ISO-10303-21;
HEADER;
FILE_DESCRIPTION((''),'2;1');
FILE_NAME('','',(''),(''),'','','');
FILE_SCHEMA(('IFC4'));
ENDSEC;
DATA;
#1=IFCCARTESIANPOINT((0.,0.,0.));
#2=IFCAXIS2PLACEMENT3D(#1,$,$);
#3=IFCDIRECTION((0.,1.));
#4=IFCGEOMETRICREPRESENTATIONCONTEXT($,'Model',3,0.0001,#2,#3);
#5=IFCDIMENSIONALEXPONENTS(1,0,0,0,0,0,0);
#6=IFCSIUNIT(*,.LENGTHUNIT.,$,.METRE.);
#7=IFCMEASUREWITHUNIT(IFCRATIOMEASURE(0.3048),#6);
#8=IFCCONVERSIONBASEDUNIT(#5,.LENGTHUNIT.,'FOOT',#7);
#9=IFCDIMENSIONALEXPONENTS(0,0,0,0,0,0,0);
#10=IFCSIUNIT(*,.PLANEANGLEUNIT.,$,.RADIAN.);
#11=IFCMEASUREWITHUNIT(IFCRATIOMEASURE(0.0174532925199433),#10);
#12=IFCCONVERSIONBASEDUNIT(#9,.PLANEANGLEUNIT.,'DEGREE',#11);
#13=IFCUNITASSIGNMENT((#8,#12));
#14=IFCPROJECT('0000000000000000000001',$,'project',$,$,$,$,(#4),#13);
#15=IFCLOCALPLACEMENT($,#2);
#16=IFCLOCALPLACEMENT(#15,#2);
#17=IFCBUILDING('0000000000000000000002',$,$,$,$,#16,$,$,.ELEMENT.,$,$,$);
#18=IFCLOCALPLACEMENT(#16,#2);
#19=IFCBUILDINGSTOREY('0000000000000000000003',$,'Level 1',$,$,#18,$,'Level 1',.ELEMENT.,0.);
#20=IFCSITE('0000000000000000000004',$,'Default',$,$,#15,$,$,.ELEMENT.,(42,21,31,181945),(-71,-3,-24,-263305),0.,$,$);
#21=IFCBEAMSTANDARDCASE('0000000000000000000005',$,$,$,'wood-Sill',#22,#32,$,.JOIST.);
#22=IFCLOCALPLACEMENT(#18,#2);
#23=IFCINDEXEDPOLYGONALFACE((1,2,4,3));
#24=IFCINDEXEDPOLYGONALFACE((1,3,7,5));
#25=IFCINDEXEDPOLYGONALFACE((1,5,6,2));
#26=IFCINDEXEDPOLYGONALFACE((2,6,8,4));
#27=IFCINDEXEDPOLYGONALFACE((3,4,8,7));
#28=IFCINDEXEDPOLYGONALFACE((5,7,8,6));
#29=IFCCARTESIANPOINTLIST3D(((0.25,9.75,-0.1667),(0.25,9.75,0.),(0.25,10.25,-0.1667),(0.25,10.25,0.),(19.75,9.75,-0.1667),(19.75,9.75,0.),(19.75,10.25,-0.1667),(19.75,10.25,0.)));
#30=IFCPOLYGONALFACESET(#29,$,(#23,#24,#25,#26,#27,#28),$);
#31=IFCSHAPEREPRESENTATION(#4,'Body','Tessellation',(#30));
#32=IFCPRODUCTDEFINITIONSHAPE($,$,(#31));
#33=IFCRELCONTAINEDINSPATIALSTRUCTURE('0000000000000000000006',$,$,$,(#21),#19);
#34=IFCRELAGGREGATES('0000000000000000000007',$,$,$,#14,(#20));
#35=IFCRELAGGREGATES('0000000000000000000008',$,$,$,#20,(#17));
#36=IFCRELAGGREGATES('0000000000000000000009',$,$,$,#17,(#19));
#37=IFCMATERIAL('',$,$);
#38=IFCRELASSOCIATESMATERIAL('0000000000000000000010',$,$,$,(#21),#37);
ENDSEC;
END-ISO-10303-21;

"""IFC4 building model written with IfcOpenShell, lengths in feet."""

from ifc_helpers import new_model, entity, si_unit, converted_unit, direction, frame, origin, place, context, project, spatial, rectangle, extrude, material, element, save


model = new_model("IFC4")

# Units and contexts
model_context = context("Model", 3, precision=0.0001, world=origin(), true_north=direction((0.0, 1.0)))
ifc_project = project(units=[converted_unit("LENGTHUNIT", "FOOT", entity("IfcRatioMeasure", 0.3048), si_unit("LENGTHUNIT", "METRE"), dimensions=[1, 0, 0, 0, 0, 0, 0]), converted_unit("PLANEANGLEUNIT", "DEGREE", entity("IfcRatioMeasure", 0.0174532925199433), si_unit("PLANEANGLEUNIT", "RADIAN"), dimensions=[0, 0, 0, 0, 0, 0, 0])], contexts=[model_context])

# Site, building, storey
site_placement = place(None, origin())
site = spatial("IfcSite", under=ifc_project, at=site_placement, Name="Default", CompositionType="ELEMENT", RefLatitude=(42, 21, 31, 181945), RefLongitude=(-71, -3, -24, -263305), RefElevation=0.0)
building_placement = place(site_placement, origin())
building = spatial("IfcBuilding", under=site, at=building_placement, CompositionType="ELEMENT")
storey_placement = place(building_placement, origin())
storey = spatial("IfcBuildingStorey", under=building, at=storey_placement, Name="Level 1", LongName="Level 1", CompositionType="ELEMENT", Elevation=0.0)

# Shared definitions
placement_1 = place(storey_placement, frame((10.0, 19.75, 0.0), z_axis=(0.0, 0.0, 1.0), x_axis=(0.0, -1.0, 0.0)))

# Beam
ifc_material_1 = material(Name="")
beam_placement = place(placement_1, frame((9.75, 0.0, -0.1667), z_axis=(0.0, 0.0, 1.0), x_axis=(0.0, -1.0, 0.0)))
element("IfcBeamStandardCase", 1, at=beam_placement, inside=storey, material=ifc_material_1, ObjectType="wood-Sill", PredefinedType="JOIST", context=model_context, shape_type="SweptSolid", body=[
    extrude(rectangle(XDim=19.5, YDim=0.5), origin(), (0.0, 0.0, 1.0), 0.1667),
])

save(model, "model.ifc")
